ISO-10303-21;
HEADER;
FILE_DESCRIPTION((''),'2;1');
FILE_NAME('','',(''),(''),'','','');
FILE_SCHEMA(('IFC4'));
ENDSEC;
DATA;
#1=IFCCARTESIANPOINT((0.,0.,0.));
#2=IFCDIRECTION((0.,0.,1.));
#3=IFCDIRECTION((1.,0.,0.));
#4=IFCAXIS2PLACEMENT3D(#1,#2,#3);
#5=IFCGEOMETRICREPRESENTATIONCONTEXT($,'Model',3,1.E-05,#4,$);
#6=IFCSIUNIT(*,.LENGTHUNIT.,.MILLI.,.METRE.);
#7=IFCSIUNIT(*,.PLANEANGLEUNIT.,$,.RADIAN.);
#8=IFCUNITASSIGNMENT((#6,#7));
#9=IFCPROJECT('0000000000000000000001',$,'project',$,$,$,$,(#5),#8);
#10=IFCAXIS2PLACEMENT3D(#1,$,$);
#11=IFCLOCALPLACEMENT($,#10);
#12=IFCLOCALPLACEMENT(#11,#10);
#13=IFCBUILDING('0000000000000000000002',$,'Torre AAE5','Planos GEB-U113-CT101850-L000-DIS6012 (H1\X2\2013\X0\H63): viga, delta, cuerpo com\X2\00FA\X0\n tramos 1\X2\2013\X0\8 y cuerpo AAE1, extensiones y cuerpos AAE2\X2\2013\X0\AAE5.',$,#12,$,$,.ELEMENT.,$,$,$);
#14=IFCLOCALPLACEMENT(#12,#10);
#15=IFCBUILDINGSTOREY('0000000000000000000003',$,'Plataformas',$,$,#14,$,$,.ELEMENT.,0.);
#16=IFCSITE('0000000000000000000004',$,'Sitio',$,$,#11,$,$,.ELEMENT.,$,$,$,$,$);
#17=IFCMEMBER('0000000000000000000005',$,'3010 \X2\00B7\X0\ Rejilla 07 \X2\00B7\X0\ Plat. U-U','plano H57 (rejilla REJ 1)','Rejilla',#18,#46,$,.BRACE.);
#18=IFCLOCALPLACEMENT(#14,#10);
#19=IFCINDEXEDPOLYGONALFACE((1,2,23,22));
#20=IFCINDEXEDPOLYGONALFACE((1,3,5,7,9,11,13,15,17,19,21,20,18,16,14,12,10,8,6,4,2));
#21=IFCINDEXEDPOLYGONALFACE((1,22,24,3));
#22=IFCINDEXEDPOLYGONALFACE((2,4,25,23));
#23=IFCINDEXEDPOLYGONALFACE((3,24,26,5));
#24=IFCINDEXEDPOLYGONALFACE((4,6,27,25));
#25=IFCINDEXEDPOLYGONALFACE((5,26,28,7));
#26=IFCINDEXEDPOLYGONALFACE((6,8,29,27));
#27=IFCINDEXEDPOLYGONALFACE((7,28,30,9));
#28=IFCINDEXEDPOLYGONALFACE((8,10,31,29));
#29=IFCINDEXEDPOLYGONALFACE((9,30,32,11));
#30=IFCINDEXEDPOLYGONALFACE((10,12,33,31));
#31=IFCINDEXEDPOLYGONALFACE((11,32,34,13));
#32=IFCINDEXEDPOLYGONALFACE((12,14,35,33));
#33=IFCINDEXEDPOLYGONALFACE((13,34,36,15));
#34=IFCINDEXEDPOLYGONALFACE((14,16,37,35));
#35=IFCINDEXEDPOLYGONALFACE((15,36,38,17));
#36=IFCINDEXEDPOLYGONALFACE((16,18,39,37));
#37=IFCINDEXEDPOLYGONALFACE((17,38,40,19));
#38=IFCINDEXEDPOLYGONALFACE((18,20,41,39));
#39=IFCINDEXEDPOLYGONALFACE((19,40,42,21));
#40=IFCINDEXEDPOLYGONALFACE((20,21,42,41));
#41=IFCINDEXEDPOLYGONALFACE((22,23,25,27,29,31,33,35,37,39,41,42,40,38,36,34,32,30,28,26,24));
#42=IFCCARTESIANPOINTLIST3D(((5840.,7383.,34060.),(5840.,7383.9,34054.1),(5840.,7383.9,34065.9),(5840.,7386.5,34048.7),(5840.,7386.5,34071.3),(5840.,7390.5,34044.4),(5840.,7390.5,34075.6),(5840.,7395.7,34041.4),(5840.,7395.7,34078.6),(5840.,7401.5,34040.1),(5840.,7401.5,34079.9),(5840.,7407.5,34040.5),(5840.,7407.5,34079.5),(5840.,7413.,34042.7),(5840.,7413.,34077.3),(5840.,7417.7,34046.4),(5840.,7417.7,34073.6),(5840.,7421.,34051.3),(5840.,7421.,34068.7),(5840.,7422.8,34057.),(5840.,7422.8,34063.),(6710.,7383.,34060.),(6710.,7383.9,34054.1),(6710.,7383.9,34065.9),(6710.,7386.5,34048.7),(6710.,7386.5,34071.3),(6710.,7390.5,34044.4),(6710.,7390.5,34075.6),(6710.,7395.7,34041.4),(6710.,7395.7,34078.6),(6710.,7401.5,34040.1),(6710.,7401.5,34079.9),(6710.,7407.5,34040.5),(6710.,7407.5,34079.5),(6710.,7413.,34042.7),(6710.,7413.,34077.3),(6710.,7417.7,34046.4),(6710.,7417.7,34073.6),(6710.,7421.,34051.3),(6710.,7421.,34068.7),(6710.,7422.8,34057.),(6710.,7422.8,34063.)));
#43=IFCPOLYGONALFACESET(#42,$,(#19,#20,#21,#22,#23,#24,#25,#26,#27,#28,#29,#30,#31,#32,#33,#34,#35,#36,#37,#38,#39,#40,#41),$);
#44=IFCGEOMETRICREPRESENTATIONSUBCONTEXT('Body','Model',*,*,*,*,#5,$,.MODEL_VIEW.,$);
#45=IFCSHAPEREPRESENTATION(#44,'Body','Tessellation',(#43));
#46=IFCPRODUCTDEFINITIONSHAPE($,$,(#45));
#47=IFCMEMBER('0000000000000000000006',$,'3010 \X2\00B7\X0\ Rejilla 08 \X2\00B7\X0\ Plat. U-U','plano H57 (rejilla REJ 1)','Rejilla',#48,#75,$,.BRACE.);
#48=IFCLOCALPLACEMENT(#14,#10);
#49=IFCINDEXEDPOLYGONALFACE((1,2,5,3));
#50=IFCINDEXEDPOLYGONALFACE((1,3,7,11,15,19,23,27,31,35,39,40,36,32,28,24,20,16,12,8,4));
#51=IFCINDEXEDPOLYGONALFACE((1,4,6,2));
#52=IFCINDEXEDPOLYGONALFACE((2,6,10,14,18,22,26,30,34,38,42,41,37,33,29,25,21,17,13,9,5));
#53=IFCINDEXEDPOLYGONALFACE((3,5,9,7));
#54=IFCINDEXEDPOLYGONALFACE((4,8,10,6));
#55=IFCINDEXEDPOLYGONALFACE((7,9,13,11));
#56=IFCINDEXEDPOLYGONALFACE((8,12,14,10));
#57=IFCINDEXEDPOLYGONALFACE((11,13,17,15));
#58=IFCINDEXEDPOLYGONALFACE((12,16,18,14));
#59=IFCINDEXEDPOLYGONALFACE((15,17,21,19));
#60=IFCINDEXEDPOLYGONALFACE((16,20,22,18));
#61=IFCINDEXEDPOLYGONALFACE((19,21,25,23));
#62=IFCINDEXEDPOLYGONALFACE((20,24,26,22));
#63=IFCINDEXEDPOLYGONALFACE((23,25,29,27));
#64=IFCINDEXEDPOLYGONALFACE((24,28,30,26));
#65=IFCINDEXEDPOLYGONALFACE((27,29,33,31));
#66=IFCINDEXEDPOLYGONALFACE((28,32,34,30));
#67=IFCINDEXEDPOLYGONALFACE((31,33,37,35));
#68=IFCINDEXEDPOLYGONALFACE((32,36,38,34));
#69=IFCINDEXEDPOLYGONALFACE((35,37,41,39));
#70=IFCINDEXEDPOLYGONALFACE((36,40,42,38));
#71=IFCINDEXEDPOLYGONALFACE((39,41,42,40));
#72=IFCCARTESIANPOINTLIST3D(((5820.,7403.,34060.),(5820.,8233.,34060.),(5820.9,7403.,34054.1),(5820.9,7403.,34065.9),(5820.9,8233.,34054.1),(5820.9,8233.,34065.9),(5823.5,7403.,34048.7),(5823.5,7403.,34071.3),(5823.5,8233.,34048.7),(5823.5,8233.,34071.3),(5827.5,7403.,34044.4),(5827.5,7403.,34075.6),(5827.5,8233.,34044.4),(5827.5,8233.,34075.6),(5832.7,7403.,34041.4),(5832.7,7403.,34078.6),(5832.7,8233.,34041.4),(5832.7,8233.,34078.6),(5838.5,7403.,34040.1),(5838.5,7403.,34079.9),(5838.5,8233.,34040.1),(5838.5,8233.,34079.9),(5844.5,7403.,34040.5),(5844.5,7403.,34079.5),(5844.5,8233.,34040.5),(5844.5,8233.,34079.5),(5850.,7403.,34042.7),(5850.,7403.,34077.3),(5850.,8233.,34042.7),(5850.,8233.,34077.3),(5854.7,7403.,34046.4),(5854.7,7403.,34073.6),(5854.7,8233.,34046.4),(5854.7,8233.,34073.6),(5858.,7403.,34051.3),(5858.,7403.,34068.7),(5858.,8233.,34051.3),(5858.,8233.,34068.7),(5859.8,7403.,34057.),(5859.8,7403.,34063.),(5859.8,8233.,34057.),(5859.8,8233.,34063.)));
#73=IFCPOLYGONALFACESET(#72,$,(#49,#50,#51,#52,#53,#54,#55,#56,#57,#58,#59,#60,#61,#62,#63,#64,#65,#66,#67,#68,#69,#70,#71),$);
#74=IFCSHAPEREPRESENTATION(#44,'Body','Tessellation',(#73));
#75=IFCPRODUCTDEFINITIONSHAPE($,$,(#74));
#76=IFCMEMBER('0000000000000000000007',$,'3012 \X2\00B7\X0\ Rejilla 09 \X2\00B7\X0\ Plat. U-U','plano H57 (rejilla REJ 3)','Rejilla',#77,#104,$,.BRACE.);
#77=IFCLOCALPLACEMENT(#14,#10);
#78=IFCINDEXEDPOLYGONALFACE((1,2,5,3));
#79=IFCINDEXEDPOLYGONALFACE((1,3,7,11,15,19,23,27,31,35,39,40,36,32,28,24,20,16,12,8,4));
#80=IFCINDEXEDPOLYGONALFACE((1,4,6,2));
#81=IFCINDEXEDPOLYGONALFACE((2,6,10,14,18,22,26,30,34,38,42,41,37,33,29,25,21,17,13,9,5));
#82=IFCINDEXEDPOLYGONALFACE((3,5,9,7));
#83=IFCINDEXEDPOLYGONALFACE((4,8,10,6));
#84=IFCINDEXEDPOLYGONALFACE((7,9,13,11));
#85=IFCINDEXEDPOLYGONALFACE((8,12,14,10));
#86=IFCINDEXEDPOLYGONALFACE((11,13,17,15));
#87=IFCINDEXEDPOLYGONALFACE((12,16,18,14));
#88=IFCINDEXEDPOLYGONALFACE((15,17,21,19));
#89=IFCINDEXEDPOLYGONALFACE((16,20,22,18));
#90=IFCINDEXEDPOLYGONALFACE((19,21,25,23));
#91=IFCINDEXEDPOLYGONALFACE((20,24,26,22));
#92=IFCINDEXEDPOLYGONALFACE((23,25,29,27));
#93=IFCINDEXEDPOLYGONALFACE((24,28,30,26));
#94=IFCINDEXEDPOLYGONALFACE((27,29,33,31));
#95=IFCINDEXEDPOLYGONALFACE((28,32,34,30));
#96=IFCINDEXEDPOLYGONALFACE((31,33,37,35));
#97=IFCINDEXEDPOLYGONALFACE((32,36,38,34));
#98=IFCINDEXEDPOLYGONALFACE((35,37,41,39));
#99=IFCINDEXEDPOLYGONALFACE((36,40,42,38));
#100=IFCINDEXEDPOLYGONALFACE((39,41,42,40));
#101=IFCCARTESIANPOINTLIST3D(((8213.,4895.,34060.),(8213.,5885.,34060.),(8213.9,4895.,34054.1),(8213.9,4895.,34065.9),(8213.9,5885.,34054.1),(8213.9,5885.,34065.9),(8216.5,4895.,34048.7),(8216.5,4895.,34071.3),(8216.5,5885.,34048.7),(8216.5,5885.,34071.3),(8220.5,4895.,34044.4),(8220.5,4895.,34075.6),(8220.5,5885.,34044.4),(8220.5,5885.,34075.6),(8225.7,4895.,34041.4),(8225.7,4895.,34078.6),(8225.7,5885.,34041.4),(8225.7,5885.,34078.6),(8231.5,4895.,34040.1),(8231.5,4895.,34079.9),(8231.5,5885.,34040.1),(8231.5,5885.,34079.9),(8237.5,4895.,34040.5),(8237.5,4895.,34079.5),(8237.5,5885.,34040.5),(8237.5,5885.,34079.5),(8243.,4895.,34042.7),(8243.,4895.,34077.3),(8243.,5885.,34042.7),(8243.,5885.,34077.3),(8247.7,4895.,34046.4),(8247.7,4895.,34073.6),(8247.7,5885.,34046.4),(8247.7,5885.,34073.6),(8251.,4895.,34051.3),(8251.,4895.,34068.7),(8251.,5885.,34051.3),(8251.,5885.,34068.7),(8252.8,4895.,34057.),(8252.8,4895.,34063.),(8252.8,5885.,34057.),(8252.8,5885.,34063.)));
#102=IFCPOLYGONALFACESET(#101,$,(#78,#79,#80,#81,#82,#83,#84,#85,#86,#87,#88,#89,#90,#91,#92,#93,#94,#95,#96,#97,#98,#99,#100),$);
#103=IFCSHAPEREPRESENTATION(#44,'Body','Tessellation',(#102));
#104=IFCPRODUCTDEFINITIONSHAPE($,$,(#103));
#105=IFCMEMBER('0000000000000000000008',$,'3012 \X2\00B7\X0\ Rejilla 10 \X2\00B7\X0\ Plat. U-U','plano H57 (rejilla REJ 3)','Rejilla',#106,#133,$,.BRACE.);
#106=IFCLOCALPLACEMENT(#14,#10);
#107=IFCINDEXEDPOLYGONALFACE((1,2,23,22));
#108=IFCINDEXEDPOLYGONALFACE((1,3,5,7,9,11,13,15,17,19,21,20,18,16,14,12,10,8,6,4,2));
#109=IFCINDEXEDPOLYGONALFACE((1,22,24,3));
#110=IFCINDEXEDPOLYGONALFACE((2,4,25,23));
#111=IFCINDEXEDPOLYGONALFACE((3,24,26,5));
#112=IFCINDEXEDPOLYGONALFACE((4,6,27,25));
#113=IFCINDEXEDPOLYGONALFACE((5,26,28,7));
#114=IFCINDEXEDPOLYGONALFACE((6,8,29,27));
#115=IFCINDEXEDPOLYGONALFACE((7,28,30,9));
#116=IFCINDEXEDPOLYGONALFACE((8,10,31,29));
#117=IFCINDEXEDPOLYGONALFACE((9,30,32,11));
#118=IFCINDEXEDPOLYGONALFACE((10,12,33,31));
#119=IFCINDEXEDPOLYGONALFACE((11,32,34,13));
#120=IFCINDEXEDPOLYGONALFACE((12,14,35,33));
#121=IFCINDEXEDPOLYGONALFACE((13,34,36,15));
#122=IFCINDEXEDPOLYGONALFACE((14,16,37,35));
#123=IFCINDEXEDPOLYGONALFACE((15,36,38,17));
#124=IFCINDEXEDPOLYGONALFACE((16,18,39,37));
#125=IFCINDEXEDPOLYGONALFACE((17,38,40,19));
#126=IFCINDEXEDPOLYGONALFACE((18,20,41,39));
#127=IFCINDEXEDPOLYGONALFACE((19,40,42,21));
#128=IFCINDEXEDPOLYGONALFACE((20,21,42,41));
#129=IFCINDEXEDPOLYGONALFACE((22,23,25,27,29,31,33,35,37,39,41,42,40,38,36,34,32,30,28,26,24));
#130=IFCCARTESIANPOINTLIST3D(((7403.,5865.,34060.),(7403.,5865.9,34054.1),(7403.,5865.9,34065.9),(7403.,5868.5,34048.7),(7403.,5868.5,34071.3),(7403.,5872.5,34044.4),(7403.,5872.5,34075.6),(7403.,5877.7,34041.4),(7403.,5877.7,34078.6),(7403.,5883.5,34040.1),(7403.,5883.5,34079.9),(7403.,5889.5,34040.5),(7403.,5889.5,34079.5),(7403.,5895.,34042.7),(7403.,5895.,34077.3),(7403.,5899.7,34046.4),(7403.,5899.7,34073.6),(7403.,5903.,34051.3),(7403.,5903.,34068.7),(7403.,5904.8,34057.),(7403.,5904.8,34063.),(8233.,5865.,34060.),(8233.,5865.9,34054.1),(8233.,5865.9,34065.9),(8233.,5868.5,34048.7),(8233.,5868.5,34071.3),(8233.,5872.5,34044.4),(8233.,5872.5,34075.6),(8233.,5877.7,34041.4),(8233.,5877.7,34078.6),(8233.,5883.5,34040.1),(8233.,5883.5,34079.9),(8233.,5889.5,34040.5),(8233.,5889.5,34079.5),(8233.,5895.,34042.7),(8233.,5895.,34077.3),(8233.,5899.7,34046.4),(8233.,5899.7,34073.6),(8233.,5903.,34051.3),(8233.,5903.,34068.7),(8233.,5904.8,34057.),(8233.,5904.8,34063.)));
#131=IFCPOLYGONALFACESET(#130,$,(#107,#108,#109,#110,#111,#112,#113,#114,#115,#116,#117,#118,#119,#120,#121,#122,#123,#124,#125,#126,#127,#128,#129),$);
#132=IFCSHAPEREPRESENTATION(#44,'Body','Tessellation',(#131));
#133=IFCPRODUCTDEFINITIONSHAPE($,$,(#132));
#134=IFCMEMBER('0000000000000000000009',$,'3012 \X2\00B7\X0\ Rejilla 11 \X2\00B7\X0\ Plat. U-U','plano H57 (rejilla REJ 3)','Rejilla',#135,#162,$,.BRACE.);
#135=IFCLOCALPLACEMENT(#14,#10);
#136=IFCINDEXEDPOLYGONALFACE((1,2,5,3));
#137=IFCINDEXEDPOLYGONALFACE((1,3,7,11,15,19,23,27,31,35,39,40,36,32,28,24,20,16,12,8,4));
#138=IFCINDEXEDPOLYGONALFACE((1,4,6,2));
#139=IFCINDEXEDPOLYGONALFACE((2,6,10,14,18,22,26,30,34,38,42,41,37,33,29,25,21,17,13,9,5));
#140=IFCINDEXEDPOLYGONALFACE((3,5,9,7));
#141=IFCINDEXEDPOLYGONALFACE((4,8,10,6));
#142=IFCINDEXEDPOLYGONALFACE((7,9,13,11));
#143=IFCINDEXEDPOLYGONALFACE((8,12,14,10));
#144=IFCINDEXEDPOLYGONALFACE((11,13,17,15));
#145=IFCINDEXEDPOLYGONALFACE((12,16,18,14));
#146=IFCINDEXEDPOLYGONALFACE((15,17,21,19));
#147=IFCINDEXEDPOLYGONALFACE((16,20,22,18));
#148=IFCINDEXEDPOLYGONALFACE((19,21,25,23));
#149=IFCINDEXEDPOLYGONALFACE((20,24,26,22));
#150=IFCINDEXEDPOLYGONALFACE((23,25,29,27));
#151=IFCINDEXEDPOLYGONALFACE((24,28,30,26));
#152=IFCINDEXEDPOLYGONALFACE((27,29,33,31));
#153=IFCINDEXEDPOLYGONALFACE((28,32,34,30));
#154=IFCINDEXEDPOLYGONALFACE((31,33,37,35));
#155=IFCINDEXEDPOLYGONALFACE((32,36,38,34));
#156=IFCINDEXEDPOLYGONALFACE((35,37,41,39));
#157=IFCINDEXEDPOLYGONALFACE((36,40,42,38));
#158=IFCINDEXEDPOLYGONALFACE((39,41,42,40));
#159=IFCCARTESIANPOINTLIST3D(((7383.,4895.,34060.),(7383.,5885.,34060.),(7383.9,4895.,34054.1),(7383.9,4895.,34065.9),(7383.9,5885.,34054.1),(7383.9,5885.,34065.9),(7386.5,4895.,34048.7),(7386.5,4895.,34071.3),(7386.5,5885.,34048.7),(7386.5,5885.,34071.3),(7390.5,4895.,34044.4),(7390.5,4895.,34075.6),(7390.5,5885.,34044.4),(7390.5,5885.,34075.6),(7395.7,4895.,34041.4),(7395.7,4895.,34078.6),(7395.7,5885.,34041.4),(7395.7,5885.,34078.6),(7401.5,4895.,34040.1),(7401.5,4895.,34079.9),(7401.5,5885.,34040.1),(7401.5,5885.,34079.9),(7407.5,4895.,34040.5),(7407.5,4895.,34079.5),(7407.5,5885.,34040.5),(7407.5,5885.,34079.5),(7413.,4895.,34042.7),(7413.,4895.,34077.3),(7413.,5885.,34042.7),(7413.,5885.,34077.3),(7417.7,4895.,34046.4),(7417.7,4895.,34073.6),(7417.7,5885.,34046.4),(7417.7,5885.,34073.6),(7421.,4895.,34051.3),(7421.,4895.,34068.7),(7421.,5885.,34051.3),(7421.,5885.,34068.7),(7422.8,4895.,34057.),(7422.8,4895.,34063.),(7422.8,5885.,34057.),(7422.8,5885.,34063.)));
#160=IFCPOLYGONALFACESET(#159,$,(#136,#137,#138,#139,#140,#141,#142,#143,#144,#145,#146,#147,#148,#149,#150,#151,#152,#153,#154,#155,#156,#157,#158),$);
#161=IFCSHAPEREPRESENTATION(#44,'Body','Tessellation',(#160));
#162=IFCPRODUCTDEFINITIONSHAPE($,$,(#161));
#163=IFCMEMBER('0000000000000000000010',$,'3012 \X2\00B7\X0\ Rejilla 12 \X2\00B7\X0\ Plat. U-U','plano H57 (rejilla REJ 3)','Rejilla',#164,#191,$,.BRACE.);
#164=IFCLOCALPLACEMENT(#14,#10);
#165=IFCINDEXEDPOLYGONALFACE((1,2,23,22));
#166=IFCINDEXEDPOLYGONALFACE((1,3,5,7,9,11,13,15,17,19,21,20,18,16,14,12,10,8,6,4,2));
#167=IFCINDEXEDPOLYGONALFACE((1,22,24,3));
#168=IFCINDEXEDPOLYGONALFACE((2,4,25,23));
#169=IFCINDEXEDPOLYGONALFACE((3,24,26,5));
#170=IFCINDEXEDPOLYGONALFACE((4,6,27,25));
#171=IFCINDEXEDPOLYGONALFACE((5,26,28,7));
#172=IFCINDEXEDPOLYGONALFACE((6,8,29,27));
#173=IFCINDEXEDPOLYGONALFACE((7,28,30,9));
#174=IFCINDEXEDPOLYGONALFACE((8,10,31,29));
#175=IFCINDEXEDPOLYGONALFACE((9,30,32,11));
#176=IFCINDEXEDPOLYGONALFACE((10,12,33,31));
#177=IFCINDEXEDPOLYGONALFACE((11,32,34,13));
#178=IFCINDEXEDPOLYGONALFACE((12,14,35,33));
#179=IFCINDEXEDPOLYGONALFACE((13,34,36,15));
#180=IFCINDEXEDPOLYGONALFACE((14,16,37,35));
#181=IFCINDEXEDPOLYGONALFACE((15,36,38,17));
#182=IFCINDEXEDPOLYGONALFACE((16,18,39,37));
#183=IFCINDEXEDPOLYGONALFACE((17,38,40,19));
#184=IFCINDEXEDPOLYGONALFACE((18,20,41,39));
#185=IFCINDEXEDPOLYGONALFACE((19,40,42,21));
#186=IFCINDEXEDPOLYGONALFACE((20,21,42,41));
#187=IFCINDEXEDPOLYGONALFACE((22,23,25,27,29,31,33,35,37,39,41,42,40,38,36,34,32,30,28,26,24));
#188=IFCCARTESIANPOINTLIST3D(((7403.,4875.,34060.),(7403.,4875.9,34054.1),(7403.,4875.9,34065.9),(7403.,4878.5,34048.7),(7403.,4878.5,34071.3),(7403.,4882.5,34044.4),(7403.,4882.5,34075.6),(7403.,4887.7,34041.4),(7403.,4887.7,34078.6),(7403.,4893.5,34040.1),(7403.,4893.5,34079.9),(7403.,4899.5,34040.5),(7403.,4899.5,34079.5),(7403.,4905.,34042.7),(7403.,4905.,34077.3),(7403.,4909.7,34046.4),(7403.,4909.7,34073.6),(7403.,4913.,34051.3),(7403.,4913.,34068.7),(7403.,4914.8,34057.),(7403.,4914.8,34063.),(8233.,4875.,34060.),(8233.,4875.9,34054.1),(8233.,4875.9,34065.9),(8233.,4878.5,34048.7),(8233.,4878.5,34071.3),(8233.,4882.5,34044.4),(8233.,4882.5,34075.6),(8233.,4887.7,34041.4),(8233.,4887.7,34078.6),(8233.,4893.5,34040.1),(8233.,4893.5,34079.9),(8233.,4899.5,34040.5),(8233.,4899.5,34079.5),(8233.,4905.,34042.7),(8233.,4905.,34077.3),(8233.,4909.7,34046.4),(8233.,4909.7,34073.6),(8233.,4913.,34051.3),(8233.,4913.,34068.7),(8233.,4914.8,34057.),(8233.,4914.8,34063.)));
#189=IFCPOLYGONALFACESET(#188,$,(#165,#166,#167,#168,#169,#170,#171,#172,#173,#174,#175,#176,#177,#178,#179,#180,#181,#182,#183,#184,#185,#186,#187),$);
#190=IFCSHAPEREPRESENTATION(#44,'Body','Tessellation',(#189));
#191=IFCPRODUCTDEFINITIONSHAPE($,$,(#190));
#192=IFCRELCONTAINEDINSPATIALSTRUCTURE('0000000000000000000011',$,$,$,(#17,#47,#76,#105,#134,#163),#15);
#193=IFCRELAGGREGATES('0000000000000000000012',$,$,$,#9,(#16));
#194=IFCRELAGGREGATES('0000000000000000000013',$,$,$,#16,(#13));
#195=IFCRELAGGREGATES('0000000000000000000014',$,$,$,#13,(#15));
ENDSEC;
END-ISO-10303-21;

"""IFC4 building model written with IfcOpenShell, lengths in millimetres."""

from ifc_helpers import new_model, si_unit, frame, origin, origin_with_axes, place, context, subcontext, project, spatial, circle, extrude, element, save


model = new_model("IFC4")

# Units and contexts
model_context = context("Model", 3, precision=1e-05, world=origin_with_axes())
body_context = subcontext(model_context, "Body", "Model", "MODEL_VIEW")
ifc_project = project(units=[si_unit("LENGTHUNIT", "METRE", prefix="MILLI"), si_unit("PLANEANGLEUNIT", "RADIAN")], contexts=[model_context])

# Site, building, storey
site_placement = place(None, origin())
site = spatial("IfcSite", under=ifc_project, at=site_placement, Name="Sitio", CompositionType="ELEMENT")
building_placement = place(site_placement, origin())
building = spatial("IfcBuilding", under=site, at=building_placement, Name="Torre AAE5", Description="Planos GEB-U113-CT101850-L000-DIS6012 (H1–H63): viga, delta, cuerpo común tramos 1–8 y cuerpo AAE1, extensiones y cuerpos AAE2–AAE5.", CompositionType="ELEMENT")
storey_placement = place(building_placement, origin())
storey = spatial("IfcBuildingStorey", under=building, at=storey_placement, Name="Plataformas", CompositionType="ELEMENT", Elevation=0.0)

# Members
member_1_placement = place(storey_placement, frame((6710.0, 7403.0, 34060.0), z_axis=(-1.0, 0.0, 0.0), x_axis=(0.0, -1.0, 0.0)))
element("IfcMember", 1, at=member_1_placement, inside=storey, Name="3010 · Rejilla 07 · Plat. U-U", Description="plano H57 (rejilla REJ 1)", ObjectType="Rejilla", PredefinedType="BRACE", context=body_context, shape_type="SweptSolid", body=[
    extrude(circle(Radius=20.0), None, (0.0, 0.0, 1.0), 870.0),
])
member_2_placement = place(storey_placement, frame((5840.0, 7403.0, 34060.0), z_axis=(0.0, 1.0, 0.0), x_axis=(-1.0, 0.0, 0.0)))
element("IfcMember", 2, at=member_2_placement, inside=storey, Name="3010 · Rejilla 08 · Plat. U-U", Description="plano H57 (rejilla REJ 1)", ObjectType="Rejilla", PredefinedType="BRACE", context=body_context, shape_type="SweptSolid", body=[
    extrude(circle(Radius=20.0), None, (0.0, 0.0, 1.0), 830.0),
])
member_3_placement = place(storey_placement, frame((8233.0, 4895.0, 34060.0), z_axis=(0.0, 1.0, 0.0), x_axis=(-1.0, 0.0, 0.0)))
element("IfcMember", 3, at=member_3_placement, inside=storey, Name="3012 · Rejilla 09 · Plat. U-U", Description="plano H57 (rejilla REJ 3)", ObjectType="Rejilla", PredefinedType="BRACE", context=body_context, shape_type="SweptSolid", body=[
    extrude(circle(Radius=20.0), None, (0.0, 0.0, 1.0), 990.0),
])
member_4_placement = place(storey_placement, frame((8233.0, 5885.0, 34060.0), z_axis=(-1.0, 0.0, 0.0), x_axis=(0.0, -1.0, 0.0)))
element("IfcMember", 4, at=member_4_placement, inside=storey, Name="3012 · Rejilla 10 · Plat. U-U", Description="plano H57 (rejilla REJ 3)", ObjectType="Rejilla", PredefinedType="BRACE", context=body_context, shape_type="SweptSolid", body=[
    extrude(circle(Radius=20.0), None, (0.0, 0.0, 1.0), 830.0),
])
member_5_placement = place(storey_placement, frame((7403.0, 5885.0, 34060.0), z_axis=(0.0, -1.0, 0.0), x_axis=(-1.0, 0.0, 0.0)))
element("IfcMember", 5, at=member_5_placement, inside=storey, Name="3012 · Rejilla 11 · Plat. U-U", Description="plano H57 (rejilla REJ 3)", ObjectType="Rejilla", PredefinedType="BRACE", context=body_context, shape_type="SweptSolid", body=[
    extrude(circle(Radius=20.0), None, (0.0, 0.0, 1.0), 990.0),
])
member_6_placement = place(storey_placement, frame((7403.0, 4895.0, 34060.0), z_axis=(1.0, 0.0, 0.0), x_axis=(0.0, -1.0, 0.0)))
element("IfcMember", 6, at=member_6_placement, inside=storey, Name="3012 · Rejilla 12 · Plat. U-U", Description="plano H57 (rejilla REJ 3)", ObjectType="Rejilla", PredefinedType="BRACE", context=body_context, shape_type="SweptSolid", body=[
    extrude(circle(Radius=20.0), None, (0.0, 0.0, 1.0), 830.0),
])

save(model, "model.ifc")
